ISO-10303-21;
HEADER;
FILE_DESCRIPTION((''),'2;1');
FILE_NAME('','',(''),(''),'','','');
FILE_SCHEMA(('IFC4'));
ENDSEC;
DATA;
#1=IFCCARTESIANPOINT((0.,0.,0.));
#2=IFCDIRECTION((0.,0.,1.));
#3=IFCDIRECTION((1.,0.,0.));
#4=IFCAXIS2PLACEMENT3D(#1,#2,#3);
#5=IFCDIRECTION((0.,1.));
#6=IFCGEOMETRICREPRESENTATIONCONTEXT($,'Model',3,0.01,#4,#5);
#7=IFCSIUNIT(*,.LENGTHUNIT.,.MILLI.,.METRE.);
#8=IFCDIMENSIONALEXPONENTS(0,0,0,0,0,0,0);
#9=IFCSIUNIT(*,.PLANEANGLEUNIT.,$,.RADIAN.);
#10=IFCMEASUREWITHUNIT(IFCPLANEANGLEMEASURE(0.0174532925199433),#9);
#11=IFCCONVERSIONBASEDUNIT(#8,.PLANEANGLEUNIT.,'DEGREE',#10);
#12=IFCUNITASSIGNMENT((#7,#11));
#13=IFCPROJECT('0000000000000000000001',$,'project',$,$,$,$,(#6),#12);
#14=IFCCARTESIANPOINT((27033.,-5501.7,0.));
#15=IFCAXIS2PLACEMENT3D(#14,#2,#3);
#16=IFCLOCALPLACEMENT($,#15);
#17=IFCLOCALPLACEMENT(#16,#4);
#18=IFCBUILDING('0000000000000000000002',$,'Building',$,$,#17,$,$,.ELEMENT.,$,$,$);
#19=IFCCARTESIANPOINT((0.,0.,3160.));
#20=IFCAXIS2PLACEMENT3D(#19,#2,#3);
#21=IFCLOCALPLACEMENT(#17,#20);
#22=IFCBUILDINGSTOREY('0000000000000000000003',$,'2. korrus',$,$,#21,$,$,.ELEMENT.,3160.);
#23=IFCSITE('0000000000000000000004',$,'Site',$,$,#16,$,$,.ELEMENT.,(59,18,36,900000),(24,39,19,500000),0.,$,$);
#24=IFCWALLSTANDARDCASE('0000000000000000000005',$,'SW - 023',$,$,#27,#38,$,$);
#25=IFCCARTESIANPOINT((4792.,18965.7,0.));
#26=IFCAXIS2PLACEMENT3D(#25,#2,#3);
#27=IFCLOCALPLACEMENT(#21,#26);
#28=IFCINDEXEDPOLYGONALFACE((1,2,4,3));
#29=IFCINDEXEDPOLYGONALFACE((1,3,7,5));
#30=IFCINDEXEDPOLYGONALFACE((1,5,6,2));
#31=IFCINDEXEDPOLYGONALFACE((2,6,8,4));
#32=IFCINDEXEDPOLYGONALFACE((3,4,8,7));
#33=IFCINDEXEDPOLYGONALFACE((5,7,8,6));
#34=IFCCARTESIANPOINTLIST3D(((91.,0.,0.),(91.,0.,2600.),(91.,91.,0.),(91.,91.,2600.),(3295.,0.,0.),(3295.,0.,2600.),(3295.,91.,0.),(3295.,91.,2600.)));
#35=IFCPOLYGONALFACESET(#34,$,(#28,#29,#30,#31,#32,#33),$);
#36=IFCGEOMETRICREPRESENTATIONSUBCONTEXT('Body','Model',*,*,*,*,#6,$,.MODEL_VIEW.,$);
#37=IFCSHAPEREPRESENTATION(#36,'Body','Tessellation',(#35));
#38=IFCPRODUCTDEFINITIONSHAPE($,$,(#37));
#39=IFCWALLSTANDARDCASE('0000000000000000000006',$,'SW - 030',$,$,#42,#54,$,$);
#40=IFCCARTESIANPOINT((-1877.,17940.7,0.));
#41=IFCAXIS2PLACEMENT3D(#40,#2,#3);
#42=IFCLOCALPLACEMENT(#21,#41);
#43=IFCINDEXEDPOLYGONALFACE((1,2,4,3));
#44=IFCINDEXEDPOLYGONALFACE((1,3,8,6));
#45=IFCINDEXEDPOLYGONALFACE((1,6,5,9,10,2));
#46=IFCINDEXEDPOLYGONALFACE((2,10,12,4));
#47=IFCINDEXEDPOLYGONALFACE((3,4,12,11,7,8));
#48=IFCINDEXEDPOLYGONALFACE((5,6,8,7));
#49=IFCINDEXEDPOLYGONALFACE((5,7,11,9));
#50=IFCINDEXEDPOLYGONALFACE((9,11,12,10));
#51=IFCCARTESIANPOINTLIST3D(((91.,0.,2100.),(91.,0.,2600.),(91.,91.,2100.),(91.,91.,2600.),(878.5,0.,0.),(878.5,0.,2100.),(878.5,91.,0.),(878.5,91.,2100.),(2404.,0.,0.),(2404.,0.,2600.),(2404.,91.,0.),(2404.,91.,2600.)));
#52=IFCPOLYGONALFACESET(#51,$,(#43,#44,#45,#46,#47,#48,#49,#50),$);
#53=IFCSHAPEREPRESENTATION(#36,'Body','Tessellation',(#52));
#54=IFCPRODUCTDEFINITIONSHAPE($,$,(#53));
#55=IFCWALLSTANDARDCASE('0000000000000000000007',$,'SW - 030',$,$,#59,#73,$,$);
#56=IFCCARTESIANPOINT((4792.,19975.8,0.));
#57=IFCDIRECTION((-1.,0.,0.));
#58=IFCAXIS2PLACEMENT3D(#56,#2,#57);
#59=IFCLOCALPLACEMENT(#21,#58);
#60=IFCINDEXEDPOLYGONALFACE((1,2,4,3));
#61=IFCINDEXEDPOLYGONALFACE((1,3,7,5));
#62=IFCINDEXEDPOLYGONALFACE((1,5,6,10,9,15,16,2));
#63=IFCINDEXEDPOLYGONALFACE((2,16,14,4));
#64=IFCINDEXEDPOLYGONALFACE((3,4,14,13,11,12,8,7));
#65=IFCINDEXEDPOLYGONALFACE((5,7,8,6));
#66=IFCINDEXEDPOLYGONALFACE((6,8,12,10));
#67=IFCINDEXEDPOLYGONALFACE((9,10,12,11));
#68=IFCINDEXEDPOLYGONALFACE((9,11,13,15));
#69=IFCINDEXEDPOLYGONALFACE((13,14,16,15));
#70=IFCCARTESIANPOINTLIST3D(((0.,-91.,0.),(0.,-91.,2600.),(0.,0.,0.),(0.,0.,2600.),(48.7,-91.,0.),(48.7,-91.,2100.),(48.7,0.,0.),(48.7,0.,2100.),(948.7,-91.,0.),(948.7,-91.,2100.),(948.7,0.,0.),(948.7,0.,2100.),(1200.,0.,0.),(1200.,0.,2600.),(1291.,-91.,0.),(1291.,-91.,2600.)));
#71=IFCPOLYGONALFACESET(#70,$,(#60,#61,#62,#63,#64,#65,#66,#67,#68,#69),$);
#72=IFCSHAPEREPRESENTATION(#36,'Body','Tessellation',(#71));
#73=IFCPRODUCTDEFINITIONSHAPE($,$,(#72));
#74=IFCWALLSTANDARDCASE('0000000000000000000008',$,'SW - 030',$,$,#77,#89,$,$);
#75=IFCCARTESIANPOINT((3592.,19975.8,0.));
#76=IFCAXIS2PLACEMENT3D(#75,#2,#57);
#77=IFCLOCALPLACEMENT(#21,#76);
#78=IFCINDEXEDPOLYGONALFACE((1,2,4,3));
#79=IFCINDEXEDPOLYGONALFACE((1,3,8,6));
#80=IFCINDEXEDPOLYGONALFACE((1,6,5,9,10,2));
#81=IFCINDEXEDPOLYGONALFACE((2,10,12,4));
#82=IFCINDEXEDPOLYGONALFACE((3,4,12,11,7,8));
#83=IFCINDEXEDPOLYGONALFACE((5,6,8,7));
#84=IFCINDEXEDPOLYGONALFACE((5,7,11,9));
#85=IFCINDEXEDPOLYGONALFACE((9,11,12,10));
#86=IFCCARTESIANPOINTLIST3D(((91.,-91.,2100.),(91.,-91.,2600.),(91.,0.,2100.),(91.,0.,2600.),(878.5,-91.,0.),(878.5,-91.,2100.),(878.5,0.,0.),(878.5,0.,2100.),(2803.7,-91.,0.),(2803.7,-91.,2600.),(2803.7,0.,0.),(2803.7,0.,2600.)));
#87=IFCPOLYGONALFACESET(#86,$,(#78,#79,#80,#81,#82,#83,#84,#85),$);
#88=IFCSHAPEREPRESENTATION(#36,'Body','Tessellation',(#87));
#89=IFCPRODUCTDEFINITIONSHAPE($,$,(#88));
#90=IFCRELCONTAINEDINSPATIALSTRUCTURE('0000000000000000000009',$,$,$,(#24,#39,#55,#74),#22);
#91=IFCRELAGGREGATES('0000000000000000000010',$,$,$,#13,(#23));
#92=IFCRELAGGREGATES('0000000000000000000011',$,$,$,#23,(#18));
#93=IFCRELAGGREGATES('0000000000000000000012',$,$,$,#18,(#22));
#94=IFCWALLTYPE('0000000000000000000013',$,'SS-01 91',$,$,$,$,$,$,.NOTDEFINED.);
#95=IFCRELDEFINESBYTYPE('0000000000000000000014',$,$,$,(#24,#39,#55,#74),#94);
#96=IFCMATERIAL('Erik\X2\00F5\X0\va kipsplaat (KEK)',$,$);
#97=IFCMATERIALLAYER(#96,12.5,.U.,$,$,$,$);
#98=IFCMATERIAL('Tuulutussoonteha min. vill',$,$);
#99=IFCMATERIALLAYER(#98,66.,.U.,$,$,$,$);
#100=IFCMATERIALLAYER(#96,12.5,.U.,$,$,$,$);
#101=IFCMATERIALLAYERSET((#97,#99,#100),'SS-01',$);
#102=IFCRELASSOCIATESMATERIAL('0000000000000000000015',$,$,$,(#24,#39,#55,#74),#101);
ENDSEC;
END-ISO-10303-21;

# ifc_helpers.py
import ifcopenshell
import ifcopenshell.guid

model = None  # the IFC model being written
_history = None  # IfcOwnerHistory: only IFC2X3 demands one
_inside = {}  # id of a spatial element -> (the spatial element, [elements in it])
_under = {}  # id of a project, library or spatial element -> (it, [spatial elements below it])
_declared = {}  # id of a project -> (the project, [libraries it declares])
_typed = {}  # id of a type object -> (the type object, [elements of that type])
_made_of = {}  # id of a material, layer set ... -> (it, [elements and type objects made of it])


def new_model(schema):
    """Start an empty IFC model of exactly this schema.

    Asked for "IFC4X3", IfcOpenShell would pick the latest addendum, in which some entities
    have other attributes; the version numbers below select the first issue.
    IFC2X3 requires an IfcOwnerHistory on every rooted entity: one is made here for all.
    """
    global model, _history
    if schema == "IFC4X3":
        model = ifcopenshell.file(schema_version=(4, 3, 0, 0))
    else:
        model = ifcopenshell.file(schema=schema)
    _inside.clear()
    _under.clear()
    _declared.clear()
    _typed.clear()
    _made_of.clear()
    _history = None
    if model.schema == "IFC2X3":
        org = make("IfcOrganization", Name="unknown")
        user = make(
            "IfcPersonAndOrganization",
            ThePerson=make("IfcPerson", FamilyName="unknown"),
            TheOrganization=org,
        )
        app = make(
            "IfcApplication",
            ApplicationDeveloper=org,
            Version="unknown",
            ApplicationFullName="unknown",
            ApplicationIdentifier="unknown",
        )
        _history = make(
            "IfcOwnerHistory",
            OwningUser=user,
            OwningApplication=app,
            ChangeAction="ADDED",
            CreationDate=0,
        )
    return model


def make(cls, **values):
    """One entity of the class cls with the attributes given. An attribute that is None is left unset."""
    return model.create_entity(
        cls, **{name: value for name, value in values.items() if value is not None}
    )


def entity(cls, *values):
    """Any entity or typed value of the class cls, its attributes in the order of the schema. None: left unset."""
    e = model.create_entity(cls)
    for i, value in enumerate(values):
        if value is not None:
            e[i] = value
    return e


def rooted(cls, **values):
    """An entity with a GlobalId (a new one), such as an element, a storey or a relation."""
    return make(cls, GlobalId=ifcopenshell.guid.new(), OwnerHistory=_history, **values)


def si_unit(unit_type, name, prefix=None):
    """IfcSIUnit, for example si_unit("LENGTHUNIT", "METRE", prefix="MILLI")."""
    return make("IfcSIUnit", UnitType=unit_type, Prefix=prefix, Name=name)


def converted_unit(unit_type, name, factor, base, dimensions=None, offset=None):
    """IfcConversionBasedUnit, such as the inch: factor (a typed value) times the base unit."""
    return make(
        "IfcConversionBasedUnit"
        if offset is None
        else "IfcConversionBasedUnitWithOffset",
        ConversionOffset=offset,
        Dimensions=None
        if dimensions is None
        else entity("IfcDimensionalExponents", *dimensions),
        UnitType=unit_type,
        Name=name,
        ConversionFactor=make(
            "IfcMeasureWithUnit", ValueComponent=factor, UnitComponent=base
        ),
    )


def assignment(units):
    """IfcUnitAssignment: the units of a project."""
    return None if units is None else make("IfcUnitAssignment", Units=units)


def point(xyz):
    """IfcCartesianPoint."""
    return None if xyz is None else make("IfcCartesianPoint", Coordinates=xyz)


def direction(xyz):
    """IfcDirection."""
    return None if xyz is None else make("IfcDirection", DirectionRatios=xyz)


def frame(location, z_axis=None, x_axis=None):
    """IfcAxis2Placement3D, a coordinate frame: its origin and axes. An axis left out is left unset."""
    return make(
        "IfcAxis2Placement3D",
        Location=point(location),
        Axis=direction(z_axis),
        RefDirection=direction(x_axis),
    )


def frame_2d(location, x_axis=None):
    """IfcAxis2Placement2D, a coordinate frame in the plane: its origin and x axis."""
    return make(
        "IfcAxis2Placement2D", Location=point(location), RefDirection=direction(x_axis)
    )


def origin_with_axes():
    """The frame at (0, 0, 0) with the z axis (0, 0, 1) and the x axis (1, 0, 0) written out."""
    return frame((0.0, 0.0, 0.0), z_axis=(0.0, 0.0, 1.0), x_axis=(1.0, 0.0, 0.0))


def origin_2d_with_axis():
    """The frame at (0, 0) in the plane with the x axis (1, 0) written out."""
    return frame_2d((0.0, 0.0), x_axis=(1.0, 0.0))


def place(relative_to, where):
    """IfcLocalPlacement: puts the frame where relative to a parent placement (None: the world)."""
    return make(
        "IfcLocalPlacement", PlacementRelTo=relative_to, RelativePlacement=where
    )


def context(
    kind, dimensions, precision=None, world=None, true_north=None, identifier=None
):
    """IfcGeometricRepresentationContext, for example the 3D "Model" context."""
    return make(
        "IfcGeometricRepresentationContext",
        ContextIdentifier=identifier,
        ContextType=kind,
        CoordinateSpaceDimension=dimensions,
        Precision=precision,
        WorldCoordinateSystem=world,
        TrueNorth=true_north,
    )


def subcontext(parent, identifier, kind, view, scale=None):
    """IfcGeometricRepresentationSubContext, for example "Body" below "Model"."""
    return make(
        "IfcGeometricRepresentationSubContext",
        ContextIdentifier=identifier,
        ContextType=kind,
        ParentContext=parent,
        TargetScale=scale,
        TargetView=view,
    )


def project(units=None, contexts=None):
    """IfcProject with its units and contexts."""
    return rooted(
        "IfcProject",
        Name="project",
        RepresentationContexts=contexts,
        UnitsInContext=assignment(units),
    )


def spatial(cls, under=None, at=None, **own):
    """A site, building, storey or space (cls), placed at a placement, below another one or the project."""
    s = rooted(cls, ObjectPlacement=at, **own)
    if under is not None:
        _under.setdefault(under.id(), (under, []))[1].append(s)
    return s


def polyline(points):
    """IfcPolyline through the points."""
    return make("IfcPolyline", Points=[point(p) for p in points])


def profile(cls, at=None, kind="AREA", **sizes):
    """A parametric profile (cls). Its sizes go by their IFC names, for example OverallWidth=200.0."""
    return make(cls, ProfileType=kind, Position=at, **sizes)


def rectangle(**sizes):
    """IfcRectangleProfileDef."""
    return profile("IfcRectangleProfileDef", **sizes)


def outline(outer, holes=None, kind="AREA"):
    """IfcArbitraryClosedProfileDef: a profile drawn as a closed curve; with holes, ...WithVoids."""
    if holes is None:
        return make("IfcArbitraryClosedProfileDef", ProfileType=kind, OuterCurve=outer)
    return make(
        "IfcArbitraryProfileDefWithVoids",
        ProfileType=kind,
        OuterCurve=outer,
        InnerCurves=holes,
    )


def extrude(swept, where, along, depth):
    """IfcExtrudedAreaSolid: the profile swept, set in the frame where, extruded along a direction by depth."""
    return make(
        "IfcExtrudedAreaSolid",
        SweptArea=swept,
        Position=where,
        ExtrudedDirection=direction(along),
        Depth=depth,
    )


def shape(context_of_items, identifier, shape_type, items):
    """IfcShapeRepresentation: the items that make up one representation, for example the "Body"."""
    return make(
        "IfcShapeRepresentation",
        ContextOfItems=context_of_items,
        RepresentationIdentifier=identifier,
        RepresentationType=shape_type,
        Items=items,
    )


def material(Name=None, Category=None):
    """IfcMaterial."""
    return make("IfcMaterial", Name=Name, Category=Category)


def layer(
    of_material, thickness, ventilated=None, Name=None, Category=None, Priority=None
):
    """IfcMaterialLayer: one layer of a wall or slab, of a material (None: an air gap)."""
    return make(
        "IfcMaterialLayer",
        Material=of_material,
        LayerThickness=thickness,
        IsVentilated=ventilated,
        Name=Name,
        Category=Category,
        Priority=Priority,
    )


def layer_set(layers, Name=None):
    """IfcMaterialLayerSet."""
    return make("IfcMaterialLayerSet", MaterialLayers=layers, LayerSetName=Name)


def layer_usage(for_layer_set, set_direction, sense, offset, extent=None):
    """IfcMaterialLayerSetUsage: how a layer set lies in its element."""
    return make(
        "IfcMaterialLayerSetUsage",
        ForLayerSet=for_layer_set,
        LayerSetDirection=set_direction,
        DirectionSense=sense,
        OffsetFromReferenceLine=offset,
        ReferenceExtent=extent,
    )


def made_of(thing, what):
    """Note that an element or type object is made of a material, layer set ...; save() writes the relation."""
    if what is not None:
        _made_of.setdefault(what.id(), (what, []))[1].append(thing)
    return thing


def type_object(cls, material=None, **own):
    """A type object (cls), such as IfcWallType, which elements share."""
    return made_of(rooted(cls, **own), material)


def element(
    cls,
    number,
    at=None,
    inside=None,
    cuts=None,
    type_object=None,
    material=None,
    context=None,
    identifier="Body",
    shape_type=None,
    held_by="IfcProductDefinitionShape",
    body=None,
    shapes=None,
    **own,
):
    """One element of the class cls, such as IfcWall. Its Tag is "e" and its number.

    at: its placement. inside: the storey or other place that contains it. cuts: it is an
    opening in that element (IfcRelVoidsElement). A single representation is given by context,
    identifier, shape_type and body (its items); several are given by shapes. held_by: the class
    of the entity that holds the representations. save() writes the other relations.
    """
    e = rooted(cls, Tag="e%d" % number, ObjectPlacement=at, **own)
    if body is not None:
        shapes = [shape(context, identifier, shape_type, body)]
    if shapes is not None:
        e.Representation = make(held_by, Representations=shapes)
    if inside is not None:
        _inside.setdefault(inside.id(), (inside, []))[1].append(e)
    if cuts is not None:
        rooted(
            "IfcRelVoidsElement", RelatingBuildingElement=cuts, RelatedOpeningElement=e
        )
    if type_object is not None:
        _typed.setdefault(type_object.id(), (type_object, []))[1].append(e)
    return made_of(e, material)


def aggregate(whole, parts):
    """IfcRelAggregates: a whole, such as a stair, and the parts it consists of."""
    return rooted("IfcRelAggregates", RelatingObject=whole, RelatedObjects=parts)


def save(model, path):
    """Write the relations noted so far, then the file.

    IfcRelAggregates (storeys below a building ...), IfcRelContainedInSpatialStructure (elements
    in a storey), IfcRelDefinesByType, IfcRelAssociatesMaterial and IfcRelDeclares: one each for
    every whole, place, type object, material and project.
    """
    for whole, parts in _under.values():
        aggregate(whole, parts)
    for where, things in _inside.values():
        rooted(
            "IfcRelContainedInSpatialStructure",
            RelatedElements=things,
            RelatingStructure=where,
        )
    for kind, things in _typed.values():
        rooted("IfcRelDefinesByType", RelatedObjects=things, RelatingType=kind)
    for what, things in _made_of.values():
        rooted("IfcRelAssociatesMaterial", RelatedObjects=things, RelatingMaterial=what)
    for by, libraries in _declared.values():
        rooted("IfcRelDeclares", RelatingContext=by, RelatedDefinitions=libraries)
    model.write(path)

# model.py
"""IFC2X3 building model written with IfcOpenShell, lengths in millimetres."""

from ifc_helpers import new_model, entity, si_unit, converted_unit, direction, frame, origin_with_axes, origin_2d_with_axis, place, context, subcontext, project, spatial, polyline, rectangle, outline, extrude, material, layer, layer_set, layer_usage, type_object, element, save


model = new_model("IFC2X3")

# Units and contexts
model_context = context("Model", 3, precision=0.01, world=origin_with_axes(), true_north=direction((0.0, 1.0)))
body_context = subcontext(model_context, "Body", "Model", "MODEL_VIEW")
ifc_project = project(units=[si_unit("LENGTHUNIT", "METRE", prefix="MILLI"), converted_unit("PLANEANGLEUNIT", "DEGREE", entity("IfcPlaneAngleMeasure", 0.0174532925199433), si_unit("PLANEANGLEUNIT", "RADIAN"), dimensions=[0, 0, 0, 0, 0, 0, 0])], contexts=[model_context])

# Site, building, storey
site_placement = place(None, frame((27033.0, -5501.7, 0.0), z_axis=(0.0, 0.0, 1.0), x_axis=(1.0, 0.0, 0.0)))
site = spatial("IfcSite", under=ifc_project, at=site_placement, Name="Site", CompositionType="ELEMENT", RefLatitude=(59, 18, 36, 900000), RefLongitude=(24, 39, 19, 500000), RefElevation=0.0)
building_placement = place(site_placement, origin_with_axes())
building = spatial("IfcBuilding", under=site, at=building_placement, Name="Building", CompositionType="ELEMENT")
storey_placement = place(building_placement, frame((0.0, 0.0, 3160.0), z_axis=(0.0, 0.0, 1.0), x_axis=(1.0, 0.0, 0.0)))
storey = spatial("IfcBuildingStorey", under=building, at=storey_placement, Name="2. korrus", CompositionType="ELEMENT", Elevation=3160.0)

# Shared definitions
ifc_material_1 = material(Name="Erikõva kipsplaat (KEK)")
ifc_layer_1 = layer(ifc_material_1, 12.5, ventilated="UNKNOWN")
ifc_material_2 = material(Name="Tuulutussoonteha min. vill")
ifc_layer_2 = layer(ifc_material_2, 66.0, ventilated="UNKNOWN")
ifc_layer_3 = layer(ifc_material_1, 12.5, ventilated="UNKNOWN")
ifc_layer_set_1 = layer_set([ifc_layer_1, ifc_layer_2, ifc_layer_3], Name="SS-01")
wall_type_1 = type_object("IfcWallType", Name="SS-01 91", PredefinedType="NOTDEFINED")

# Wall
ifc_layer_usage_1 = layer_usage(ifc_layer_set_1, "AXIS2", "NEGATIVE", 91.0)
wall_1_placement = place(storey_placement, frame((4792.0, 18965.7, 0.0), z_axis=(0.0, 0.0, 1.0), x_axis=(1.0, 0.0, 0.0)))
element("IfcWallStandardCase", 1, at=wall_1_placement, inside=storey, type_object=wall_type_1, material=ifc_layer_usage_1, Name="SW - 023", context=body_context, shape_type="SweptSolid", body=[
    extrude(outline(polyline([(91.0, 0.0), (3295.0, 0.0), (3295.0, 91.0), (91.0, 91.0), (91.0, 0.0)])), origin_with_axes(), (0.0, 0.0, 1.0), 2600.0),
])

# Walls, openings
ifc_layer_usage_2 = layer_usage(ifc_layer_set_1, "AXIS2", "NEGATIVE", 91.0)
wall_2_placement = place(storey_placement, frame((-1877.0, 17940.7, 0.0), z_axis=(0.0, 0.0, 1.0), x_axis=(1.0, 0.0, 0.0)))
wall_2 = element("IfcWallStandardCase", 2, at=wall_2_placement, inside=storey, type_object=wall_type_1, material=ifc_layer_usage_2, Name="SW - 030", context=body_context, shape_type="SweptSolid", body=[
    extrude(outline(polyline([(91.0, 0.0), (2404.0, 0.0), (2404.0, 91.0), (91.0, 91.0), (91.0, 0.0)])), origin_with_axes(), (0.0, 0.0, 1.0), 2600.0),
])
opening_1_placement = place(wall_2_placement, frame((478.5, 0.0, 0.0), z_axis=(0.0, 0.0, 1.0), x_axis=(1.0, 0.0, 0.0)))
element("IfcOpeningElement", 3, at=opening_1_placement, cuts=wall_2, context=body_context, shape_type="SweptSolid", body=[
    extrude(rectangle(XDim=800.0, YDim=2100.0, at=origin_2d_with_axis()), frame((0.0, -91.0, 1050.0), z_axis=(0.0, 1.0, 0.0), x_axis=(1.0, 0.0, 0.0)), (0.0, 0.0, 1.0), 273.0),
])
ifc_layer_usage_3 = layer_usage(ifc_layer_set_1, "AXIS2", "POSITIVE", -91.0)
wall_3_placement = place(storey_placement, frame((4792.0, 19975.8, 0.0), z_axis=(0.0, 0.0, 1.0), x_axis=(-1.0, 0.0, 0.0)))
wall_3 = element("IfcWallStandardCase", 4, at=wall_3_placement, inside=storey, type_object=wall_type_1, material=ifc_layer_usage_3, Name="SW - 030", context=body_context, shape_type="SweptSolid", body=[
    extrude(outline(polyline([(0.0, -91.0), (1291.0, -91.0), (1200.0, 0.0), (0.0, 0.0), (0.0, -91.0)])), origin_with_axes(), (0.0, 0.0, 1.0), 2600.0),
])
opening_2_placement = place(wall_3_placement, frame((498.7, 0.0, 0.0), z_axis=(0.0, 0.0, 1.0), x_axis=(1.0, 0.0, 0.0)))
element("IfcOpeningElement", 5, at=opening_2_placement, cuts=wall_3, context=body_context, shape_type="SweptSolid", body=[
    extrude(rectangle(XDim=900.0, YDim=2100.0, at=origin_2d_with_axis()), frame((0.0, -91.0, 1050.0), z_axis=(0.0, 1.0, 0.0), x_axis=(-1.0, 0.0, 0.0)), (0.0, 0.0, 1.0), 273.0),
    extrude(rectangle(XDim=974.0, YDim=2137.0, at=origin_2d_with_axis()), frame((0.0, 0.0, 1068.5), z_axis=(0.0, -1.0, 0.0), x_axis=(-1.0, 0.0, 0.0)), (0.0, 0.0, -1.0), 91.0),
])
ifc_layer_usage_4 = layer_usage(ifc_layer_set_1, "AXIS2", "POSITIVE", -91.0)
wall_4_placement = place(storey_placement, frame((3592.0, 19975.8, 0.0), z_axis=(0.0, 0.0, 1.0), x_axis=(-1.0, 0.0, 0.0)))
wall_4 = element("IfcWallStandardCase", 6, at=wall_4_placement, inside=storey, type_object=wall_type_1, material=ifc_layer_usage_4, Name="SW - 030", context=body_context, shape_type="SweptSolid", body=[
    extrude(outline(polyline([(91.0, -91.0), (2803.7, -91.0), (2803.7, 0.0), (91.0, 0.0), (91.0, -91.0)])), origin_with_axes(), (0.0, 0.0, 1.0), 2600.0),
])
opening_3_placement = place(wall_4_placement, frame((478.5, 0.0, 0.0), z_axis=(0.0, 0.0, 1.0), x_axis=(1.0, 0.0, 0.0)))
element("IfcOpeningElement", 7, at=opening_3_placement, cuts=wall_4, context=body_context, shape_type="SweptSolid", body=[
    extrude(rectangle(XDim=800.0, YDim=2100.0, at=origin_2d_with_axis()), frame((0.0, 91.0, 1050.0), z_axis=(0.0, 1.0, 0.0), x_axis=(1.0, 0.0, 0.0)), (0.0, 0.0, -1.0), 273.0),
])

save(model, "model.ifc")
